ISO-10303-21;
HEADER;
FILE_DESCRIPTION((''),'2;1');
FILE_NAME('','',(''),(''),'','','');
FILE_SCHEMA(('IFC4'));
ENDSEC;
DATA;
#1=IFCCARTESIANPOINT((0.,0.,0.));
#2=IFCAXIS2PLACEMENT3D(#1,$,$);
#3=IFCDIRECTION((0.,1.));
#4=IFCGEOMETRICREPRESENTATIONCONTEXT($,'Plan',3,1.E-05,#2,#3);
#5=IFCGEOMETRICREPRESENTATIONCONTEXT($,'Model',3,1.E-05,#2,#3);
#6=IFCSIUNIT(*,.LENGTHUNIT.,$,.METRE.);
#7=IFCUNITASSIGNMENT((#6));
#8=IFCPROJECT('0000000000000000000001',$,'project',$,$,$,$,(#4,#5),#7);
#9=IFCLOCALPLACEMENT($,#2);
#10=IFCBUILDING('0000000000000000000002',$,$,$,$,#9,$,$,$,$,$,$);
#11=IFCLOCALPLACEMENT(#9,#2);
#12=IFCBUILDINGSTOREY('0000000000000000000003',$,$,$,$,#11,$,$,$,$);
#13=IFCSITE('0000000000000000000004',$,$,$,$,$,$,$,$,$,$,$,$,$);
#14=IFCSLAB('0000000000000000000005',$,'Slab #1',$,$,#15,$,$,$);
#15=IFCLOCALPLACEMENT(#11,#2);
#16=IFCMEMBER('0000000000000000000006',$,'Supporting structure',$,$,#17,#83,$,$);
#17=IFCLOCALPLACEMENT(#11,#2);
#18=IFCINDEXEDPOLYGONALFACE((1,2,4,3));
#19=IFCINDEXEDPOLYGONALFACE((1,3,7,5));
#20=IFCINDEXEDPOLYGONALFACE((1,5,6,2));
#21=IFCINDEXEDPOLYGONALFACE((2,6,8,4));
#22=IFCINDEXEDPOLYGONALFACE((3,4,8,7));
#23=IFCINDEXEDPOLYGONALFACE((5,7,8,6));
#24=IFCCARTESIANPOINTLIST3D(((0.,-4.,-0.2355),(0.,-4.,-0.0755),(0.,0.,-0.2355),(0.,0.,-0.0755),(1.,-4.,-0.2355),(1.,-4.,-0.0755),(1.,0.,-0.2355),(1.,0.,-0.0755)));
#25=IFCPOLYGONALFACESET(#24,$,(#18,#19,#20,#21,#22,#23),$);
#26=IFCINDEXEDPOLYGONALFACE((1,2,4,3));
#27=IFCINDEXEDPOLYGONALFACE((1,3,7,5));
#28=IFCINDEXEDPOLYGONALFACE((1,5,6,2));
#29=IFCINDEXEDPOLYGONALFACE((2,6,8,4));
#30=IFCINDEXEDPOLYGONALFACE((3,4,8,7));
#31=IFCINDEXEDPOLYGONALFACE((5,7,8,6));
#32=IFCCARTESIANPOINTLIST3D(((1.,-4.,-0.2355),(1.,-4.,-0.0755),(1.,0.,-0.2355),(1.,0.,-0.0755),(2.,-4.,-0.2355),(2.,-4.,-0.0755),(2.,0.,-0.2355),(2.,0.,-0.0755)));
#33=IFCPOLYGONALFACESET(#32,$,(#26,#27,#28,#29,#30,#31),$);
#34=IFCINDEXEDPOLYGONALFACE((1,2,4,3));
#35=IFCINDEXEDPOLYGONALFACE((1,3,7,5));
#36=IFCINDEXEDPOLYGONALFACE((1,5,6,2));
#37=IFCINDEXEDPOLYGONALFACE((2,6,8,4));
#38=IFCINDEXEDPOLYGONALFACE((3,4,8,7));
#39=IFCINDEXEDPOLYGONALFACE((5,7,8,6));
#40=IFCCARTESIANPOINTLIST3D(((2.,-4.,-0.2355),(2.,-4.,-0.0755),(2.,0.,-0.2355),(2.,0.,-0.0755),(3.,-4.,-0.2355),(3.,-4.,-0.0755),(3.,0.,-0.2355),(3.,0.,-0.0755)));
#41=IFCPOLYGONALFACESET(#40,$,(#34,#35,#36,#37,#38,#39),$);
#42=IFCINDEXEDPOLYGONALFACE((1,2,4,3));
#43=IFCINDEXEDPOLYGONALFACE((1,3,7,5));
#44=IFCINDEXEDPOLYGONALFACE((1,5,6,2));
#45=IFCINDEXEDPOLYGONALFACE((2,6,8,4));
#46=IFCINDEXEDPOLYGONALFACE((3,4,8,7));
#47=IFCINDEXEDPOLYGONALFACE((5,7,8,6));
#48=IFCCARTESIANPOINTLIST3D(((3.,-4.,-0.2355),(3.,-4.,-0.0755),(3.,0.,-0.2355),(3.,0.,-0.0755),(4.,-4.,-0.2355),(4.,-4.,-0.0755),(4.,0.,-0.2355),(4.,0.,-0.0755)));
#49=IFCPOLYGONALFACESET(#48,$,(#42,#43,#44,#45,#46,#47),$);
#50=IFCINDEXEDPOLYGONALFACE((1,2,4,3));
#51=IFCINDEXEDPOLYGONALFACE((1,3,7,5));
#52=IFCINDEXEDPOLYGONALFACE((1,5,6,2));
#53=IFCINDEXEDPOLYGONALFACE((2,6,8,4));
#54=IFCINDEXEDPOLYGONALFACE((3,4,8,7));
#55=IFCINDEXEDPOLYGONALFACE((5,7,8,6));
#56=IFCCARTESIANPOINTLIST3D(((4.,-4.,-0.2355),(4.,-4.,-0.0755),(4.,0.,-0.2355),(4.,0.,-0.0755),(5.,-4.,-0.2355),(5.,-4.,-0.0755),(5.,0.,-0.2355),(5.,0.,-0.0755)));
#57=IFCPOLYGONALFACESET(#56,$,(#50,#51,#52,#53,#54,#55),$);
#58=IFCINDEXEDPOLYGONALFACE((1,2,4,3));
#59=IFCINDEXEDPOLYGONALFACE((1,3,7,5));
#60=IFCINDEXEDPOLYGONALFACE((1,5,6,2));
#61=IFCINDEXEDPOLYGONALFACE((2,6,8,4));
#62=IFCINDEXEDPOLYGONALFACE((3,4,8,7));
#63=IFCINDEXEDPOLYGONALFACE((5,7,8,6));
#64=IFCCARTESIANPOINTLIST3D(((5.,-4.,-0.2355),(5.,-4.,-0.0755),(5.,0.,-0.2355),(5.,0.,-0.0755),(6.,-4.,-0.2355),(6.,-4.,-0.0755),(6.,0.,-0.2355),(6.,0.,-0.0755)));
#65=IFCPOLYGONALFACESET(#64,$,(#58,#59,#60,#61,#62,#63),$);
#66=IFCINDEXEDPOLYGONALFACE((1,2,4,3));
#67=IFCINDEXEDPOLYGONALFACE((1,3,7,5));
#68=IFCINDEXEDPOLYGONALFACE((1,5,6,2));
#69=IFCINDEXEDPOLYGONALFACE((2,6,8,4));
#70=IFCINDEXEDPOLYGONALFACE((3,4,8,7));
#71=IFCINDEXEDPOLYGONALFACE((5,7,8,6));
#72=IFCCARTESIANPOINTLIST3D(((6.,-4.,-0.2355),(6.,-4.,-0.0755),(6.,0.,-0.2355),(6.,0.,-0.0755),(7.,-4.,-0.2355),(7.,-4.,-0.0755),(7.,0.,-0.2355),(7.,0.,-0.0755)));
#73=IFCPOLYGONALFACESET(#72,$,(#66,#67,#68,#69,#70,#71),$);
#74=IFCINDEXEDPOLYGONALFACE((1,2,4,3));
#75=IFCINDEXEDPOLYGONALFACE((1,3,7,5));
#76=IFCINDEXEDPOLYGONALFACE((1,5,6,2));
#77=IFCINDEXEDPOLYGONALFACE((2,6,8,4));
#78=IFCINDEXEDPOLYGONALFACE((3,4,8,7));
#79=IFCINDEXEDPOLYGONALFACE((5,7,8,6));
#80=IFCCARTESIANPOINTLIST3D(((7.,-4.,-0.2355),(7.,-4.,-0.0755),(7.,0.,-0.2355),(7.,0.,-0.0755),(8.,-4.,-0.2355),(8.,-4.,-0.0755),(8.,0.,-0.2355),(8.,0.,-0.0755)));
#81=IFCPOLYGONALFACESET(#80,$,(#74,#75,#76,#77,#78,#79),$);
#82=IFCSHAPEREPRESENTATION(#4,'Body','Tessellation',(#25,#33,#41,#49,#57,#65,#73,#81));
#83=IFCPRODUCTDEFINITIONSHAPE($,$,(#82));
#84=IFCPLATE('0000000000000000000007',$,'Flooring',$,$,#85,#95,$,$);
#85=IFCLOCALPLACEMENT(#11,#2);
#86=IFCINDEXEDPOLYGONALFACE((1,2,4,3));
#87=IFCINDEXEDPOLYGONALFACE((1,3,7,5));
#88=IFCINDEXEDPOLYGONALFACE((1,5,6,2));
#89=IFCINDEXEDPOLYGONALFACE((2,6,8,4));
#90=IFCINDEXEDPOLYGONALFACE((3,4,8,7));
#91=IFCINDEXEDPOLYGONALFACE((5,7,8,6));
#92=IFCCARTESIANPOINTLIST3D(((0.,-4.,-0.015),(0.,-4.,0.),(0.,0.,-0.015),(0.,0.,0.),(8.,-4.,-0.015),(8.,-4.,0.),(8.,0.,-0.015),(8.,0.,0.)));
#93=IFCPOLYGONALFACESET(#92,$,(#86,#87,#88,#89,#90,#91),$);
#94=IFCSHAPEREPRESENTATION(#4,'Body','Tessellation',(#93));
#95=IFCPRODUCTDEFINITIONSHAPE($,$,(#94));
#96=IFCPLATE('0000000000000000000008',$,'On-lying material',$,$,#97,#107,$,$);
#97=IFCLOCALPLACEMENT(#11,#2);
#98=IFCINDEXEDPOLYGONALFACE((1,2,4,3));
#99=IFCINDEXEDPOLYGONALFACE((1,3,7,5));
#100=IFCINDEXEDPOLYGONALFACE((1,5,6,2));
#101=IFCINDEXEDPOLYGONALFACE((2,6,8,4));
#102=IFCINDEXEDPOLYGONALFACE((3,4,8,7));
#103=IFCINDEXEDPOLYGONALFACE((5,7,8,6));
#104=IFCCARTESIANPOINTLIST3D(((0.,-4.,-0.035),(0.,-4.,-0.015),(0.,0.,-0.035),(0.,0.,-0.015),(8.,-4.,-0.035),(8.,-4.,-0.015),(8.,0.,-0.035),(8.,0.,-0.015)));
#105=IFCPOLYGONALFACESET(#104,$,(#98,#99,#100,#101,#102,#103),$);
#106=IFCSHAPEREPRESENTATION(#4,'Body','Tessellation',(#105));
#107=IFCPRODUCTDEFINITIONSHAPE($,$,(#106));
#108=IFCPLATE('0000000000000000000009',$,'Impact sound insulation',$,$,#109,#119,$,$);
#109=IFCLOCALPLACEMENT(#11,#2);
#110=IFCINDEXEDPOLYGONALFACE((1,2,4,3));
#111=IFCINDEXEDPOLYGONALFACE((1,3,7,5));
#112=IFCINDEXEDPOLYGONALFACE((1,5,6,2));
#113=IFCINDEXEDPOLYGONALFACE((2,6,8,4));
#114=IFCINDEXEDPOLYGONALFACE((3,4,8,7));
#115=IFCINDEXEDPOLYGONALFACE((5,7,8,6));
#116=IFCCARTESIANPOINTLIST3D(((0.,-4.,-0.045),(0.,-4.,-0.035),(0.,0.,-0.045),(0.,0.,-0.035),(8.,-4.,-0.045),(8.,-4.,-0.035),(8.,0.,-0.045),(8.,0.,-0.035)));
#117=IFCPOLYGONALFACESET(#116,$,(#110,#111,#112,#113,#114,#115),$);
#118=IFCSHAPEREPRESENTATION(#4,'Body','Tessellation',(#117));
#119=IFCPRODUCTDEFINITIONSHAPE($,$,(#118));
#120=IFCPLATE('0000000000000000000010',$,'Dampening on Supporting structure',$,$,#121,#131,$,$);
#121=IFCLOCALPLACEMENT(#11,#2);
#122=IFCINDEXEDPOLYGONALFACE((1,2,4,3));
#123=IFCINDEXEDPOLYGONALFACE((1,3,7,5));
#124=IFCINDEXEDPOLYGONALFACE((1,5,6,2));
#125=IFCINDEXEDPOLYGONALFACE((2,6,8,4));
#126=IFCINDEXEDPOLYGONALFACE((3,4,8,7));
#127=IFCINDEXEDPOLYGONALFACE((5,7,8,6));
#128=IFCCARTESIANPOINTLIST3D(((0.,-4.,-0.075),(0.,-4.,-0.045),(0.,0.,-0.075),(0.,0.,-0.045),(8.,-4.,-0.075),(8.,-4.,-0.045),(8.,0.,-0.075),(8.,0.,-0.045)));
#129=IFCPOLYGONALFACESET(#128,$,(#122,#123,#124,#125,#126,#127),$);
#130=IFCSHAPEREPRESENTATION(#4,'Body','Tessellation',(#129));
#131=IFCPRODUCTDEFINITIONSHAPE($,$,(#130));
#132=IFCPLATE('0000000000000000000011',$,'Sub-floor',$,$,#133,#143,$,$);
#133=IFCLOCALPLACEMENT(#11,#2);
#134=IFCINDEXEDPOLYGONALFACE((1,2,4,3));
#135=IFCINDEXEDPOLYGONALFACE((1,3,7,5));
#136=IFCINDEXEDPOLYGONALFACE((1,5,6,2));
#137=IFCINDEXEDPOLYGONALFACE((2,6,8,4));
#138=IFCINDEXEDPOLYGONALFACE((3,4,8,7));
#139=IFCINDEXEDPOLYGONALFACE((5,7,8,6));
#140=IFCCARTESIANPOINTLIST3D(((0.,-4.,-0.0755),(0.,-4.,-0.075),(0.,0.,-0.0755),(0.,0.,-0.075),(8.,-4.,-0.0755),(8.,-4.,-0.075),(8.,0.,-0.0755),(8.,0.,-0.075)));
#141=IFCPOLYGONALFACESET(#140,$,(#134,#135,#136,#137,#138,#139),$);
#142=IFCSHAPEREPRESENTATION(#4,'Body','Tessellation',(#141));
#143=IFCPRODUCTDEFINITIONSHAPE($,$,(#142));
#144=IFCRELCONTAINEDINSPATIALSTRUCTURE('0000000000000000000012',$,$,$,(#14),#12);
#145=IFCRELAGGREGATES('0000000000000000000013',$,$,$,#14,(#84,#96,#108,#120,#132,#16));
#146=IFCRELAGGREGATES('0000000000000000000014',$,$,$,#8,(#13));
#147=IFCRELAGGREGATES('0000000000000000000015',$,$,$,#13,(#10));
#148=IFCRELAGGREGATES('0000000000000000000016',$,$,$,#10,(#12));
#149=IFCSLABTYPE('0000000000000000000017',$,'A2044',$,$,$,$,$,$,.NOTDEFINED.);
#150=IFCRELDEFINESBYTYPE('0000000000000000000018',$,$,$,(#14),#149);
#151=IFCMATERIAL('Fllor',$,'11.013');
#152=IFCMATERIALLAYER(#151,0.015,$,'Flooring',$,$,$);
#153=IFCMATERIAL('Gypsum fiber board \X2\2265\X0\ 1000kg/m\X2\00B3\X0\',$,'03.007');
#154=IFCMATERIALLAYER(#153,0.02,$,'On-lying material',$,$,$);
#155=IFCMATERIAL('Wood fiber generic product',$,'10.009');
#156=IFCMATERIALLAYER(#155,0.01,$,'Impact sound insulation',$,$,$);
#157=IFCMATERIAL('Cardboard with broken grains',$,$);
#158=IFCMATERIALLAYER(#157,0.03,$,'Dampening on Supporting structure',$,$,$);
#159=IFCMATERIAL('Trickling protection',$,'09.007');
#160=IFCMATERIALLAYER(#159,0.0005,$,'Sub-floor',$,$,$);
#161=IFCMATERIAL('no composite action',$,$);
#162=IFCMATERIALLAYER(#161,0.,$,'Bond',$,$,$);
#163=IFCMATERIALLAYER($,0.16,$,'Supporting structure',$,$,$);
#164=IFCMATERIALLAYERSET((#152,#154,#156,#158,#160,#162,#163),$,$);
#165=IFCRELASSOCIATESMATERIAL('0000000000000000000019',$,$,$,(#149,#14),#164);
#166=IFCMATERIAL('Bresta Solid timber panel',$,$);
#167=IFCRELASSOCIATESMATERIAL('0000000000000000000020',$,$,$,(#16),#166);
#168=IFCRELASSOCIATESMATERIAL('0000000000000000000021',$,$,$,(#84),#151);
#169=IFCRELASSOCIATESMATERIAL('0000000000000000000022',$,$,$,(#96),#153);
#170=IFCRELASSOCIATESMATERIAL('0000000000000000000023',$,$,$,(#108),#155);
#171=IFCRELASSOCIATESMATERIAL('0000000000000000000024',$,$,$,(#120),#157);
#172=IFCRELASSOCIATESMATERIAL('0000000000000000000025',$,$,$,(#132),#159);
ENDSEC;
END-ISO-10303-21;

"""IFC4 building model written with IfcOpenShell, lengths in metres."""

from ifc_helpers import new_model, si_unit, direction, frame, frame_2d, origin, origin_with_axes, place, context, project, spatial, rectangle, extrude, material, layer, layer_set, type_object, element, aggregate, save


model = new_model("IFC4")

# Units and contexts
plan_context = context("Plan", 3, precision=1e-05, world=origin(), true_north=direction((0.0, 1.0)))
model_context = context("Model", 3, precision=1e-05, world=origin(), true_north=direction((0.0, 1.0)))
ifc_project = project(units=[si_unit("LENGTHUNIT", "METRE")], contexts=[plan_context, model_context])

# Site, building, storey
site = spatial("IfcSite", under=ifc_project)
building_placement = place(None, origin())
building = spatial("IfcBuilding", under=site, at=building_placement)
storey_placement = place(building_placement, origin())
storey = spatial("IfcBuildingStorey", under=building, at=storey_placement)

# Slab, member, plates
ifc_material_1 = material(Name="Fllor", Category="11.013")
ifc_layer_1 = layer(ifc_material_1, 0.015, Name="Flooring")
ifc_material_2 = material(Name="Gypsum fiber board ≥ 1000kg/m³", Category="03.007")
ifc_layer_2 = layer(ifc_material_2, 0.02, Name="On-lying material")
ifc_material_3 = material(Name="Wood fiber generic product", Category="10.009")
ifc_layer_3 = layer(ifc_material_3, 0.01, Name="Impact sound insulation")
ifc_material_4 = material(Name="Cardboard with broken grains")
ifc_layer_4 = layer(ifc_material_4, 0.03, Name="Dampening on Supporting structure")
ifc_material_5 = material(Name="Trickling protection", Category="09.007")
ifc_layer_5 = layer(ifc_material_5, 0.0005, Name="Sub-floor")
ifc_material_6 = material(Name="no composite action")
ifc_layer_6 = layer(ifc_material_6, 0.0, Name="Bond")
ifc_layer_7 = layer(None, 0.16, Name="Supporting structure")
ifc_layer_set = layer_set([ifc_layer_1, ifc_layer_2, ifc_layer_3, ifc_layer_4, ifc_layer_5, ifc_layer_6, ifc_layer_7])
slab_type = type_object("IfcSlabType", Name="A2044", PredefinedType="NOTDEFINED", material=ifc_layer_set)
slab_placement = place(None, frame((0.0, 0.0, 0.0), z_axis=(0.0, 0.0, -1.0), x_axis=(1.0, 0.0, 0.0)))
slab = element("IfcSlab", 1, at=slab_placement, inside=storey, type_object=slab_type, material=ifc_layer_set, Name="Slab #1")
ifc_material_7 = material(Name="Bresta Solid timber panel")
member_placement = place(slab_placement, origin())
member = element("IfcMember", 2, at=member_placement, material=ifc_material_7, Name="Supporting structure", context=plan_context, shape_type="SweptSolid", body=[
    extrude(rectangle(XDim=1.0, YDim=0.16, at=frame_2d((0.5, 0.08), x_axis=(1.0, 0.0))), frame((0.0, 4.0, 0.0755), z_axis=(0.0, -1.0, 0.0), x_axis=(1.0, 0.0, 0.0)), (0.0, 0.0, 1.0), 4.0),
    extrude(rectangle(XDim=1.0, YDim=0.16, at=frame_2d((0.5, 0.08), x_axis=(1.0, 0.0))), frame((1.0, 4.0, 0.0755), z_axis=(0.0, -1.0, 0.0), x_axis=(1.0, 0.0, 0.0)), (0.0, 0.0, 1.0), 4.0),
    extrude(rectangle(XDim=1.0, YDim=0.16, at=frame_2d((0.5, 0.08), x_axis=(1.0, 0.0))), frame((2.0, 4.0, 0.0755), z_axis=(0.0, -1.0, 0.0), x_axis=(1.0, 0.0, 0.0)), (0.0, 0.0, 1.0), 4.0),
    extrude(rectangle(XDim=1.0, YDim=0.16, at=frame_2d((0.5, 0.08), x_axis=(1.0, 0.0))), frame((3.0, 4.0, 0.0755), z_axis=(0.0, -1.0, 0.0), x_axis=(1.0, 0.0, 0.0)), (0.0, 0.0, 1.0), 4.0),
    extrude(rectangle(XDim=1.0, YDim=0.16, at=frame_2d((0.5, 0.08), x_axis=(1.0, 0.0))), frame((4.0, 4.0, 0.0755), z_axis=(0.0, -1.0, 0.0), x_axis=(1.0, 0.0, 0.0)), (0.0, 0.0, 1.0), 4.0),
    extrude(rectangle(XDim=1.0, YDim=0.16, at=frame_2d((0.5, 0.08), x_axis=(1.0, 0.0))), frame((5.0, 4.0, 0.0755), z_axis=(0.0, -1.0, 0.0), x_axis=(1.0, 0.0, 0.0)), (0.0, 0.0, 1.0), 4.0),
    extrude(rectangle(XDim=1.0, YDim=0.16, at=frame_2d((0.5, 0.08), x_axis=(1.0, 0.0))), frame((6.0, 4.0, 0.0755), z_axis=(0.0, -1.0, 0.0), x_axis=(1.0, 0.0, 0.0)), (0.0, 0.0, 1.0), 4.0),
    extrude(rectangle(XDim=1.0, YDim=0.16, at=frame_2d((0.5, 0.08), x_axis=(1.0, 0.0))), frame((7.0, 4.0, 0.0755), z_axis=(0.0, -1.0, 0.0), x_axis=(1.0, 0.0, 0.0)), (0.0, 0.0, 1.0), 4.0),
])
plate_1_placement = place(slab_placement, origin())
plate_1 = element("IfcPlate", 3, at=plate_1_placement, material=ifc_material_1, Name="Flooring", context=plan_context, shape_type="SweptSolid", body=[
    extrude(rectangle(XDim=8.0, YDim=4.0, at=frame_2d((4.0, 2.0), x_axis=(1.0, 0.0))), origin_with_axes(), (0.0, 0.0, 1.0), 0.015),
])
plate_2_placement = place(slab_placement, origin())
plate_2 = element("IfcPlate", 4, at=plate_2_placement, material=ifc_material_2, Name="On-lying material", context=plan_context, shape_type="SweptSolid", body=[
    extrude(rectangle(XDim=8.0, YDim=4.0, at=frame_2d((4.0, 2.0), x_axis=(1.0, 0.0))), frame((0.0, 0.0, 0.015), z_axis=(0.0, 0.0, 1.0), x_axis=(1.0, 0.0, 0.0)), (0.0, 0.0, 1.0), 0.02),
])
plate_3_placement = place(slab_placement, origin())
plate_3 = element("IfcPlate", 5, at=plate_3_placement, material=ifc_material_3, Name="Impact sound insulation", context=plan_context, shape_type="SweptSolid", body=[
    extrude(rectangle(XDim=8.0, YDim=4.0, at=frame_2d((4.0, 2.0), x_axis=(1.0, 0.0))), frame((0.0, 0.0, 0.035), z_axis=(0.0, 0.0, 1.0), x_axis=(1.0, 0.0, 0.0)), (0.0, 0.0, 1.0), 0.01),
])
plate_4_placement = place(slab_placement, origin())
plate_4 = element("IfcPlate", 6, at=plate_4_placement, material=ifc_material_4, Name="Dampening on Supporting structure", context=plan_context, shape_type="SweptSolid", body=[
    extrude(rectangle(XDim=8.0, YDim=4.0, at=frame_2d((4.0, 2.0), x_axis=(1.0, 0.0))), frame((0.0, 0.0, 0.045), z_axis=(0.0, 0.0, 1.0), x_axis=(1.0, 0.0, 0.0)), (0.0, 0.0, 1.0), 0.03),
])
plate_5_placement = place(slab_placement, origin())
plate_5 = element("IfcPlate", 7, at=plate_5_placement, material=ifc_material_5, Name="Sub-floor", context=plan_context, shape_type="SweptSolid", body=[
    extrude(rectangle(XDim=8.0, YDim=4.0, at=frame_2d((4.0, 2.0), x_axis=(1.0, 0.0))), frame((0.0, 0.0, 0.075), z_axis=(0.0, 0.0, 1.0), x_axis=(1.0, 0.0, 0.0)), (0.0, 0.0, 1.0), 0.0005),
])
aggregate(slab, [plate_1, plate_2, plate_3, plate_4, plate_5, member])

save(model, "model.ifc")
